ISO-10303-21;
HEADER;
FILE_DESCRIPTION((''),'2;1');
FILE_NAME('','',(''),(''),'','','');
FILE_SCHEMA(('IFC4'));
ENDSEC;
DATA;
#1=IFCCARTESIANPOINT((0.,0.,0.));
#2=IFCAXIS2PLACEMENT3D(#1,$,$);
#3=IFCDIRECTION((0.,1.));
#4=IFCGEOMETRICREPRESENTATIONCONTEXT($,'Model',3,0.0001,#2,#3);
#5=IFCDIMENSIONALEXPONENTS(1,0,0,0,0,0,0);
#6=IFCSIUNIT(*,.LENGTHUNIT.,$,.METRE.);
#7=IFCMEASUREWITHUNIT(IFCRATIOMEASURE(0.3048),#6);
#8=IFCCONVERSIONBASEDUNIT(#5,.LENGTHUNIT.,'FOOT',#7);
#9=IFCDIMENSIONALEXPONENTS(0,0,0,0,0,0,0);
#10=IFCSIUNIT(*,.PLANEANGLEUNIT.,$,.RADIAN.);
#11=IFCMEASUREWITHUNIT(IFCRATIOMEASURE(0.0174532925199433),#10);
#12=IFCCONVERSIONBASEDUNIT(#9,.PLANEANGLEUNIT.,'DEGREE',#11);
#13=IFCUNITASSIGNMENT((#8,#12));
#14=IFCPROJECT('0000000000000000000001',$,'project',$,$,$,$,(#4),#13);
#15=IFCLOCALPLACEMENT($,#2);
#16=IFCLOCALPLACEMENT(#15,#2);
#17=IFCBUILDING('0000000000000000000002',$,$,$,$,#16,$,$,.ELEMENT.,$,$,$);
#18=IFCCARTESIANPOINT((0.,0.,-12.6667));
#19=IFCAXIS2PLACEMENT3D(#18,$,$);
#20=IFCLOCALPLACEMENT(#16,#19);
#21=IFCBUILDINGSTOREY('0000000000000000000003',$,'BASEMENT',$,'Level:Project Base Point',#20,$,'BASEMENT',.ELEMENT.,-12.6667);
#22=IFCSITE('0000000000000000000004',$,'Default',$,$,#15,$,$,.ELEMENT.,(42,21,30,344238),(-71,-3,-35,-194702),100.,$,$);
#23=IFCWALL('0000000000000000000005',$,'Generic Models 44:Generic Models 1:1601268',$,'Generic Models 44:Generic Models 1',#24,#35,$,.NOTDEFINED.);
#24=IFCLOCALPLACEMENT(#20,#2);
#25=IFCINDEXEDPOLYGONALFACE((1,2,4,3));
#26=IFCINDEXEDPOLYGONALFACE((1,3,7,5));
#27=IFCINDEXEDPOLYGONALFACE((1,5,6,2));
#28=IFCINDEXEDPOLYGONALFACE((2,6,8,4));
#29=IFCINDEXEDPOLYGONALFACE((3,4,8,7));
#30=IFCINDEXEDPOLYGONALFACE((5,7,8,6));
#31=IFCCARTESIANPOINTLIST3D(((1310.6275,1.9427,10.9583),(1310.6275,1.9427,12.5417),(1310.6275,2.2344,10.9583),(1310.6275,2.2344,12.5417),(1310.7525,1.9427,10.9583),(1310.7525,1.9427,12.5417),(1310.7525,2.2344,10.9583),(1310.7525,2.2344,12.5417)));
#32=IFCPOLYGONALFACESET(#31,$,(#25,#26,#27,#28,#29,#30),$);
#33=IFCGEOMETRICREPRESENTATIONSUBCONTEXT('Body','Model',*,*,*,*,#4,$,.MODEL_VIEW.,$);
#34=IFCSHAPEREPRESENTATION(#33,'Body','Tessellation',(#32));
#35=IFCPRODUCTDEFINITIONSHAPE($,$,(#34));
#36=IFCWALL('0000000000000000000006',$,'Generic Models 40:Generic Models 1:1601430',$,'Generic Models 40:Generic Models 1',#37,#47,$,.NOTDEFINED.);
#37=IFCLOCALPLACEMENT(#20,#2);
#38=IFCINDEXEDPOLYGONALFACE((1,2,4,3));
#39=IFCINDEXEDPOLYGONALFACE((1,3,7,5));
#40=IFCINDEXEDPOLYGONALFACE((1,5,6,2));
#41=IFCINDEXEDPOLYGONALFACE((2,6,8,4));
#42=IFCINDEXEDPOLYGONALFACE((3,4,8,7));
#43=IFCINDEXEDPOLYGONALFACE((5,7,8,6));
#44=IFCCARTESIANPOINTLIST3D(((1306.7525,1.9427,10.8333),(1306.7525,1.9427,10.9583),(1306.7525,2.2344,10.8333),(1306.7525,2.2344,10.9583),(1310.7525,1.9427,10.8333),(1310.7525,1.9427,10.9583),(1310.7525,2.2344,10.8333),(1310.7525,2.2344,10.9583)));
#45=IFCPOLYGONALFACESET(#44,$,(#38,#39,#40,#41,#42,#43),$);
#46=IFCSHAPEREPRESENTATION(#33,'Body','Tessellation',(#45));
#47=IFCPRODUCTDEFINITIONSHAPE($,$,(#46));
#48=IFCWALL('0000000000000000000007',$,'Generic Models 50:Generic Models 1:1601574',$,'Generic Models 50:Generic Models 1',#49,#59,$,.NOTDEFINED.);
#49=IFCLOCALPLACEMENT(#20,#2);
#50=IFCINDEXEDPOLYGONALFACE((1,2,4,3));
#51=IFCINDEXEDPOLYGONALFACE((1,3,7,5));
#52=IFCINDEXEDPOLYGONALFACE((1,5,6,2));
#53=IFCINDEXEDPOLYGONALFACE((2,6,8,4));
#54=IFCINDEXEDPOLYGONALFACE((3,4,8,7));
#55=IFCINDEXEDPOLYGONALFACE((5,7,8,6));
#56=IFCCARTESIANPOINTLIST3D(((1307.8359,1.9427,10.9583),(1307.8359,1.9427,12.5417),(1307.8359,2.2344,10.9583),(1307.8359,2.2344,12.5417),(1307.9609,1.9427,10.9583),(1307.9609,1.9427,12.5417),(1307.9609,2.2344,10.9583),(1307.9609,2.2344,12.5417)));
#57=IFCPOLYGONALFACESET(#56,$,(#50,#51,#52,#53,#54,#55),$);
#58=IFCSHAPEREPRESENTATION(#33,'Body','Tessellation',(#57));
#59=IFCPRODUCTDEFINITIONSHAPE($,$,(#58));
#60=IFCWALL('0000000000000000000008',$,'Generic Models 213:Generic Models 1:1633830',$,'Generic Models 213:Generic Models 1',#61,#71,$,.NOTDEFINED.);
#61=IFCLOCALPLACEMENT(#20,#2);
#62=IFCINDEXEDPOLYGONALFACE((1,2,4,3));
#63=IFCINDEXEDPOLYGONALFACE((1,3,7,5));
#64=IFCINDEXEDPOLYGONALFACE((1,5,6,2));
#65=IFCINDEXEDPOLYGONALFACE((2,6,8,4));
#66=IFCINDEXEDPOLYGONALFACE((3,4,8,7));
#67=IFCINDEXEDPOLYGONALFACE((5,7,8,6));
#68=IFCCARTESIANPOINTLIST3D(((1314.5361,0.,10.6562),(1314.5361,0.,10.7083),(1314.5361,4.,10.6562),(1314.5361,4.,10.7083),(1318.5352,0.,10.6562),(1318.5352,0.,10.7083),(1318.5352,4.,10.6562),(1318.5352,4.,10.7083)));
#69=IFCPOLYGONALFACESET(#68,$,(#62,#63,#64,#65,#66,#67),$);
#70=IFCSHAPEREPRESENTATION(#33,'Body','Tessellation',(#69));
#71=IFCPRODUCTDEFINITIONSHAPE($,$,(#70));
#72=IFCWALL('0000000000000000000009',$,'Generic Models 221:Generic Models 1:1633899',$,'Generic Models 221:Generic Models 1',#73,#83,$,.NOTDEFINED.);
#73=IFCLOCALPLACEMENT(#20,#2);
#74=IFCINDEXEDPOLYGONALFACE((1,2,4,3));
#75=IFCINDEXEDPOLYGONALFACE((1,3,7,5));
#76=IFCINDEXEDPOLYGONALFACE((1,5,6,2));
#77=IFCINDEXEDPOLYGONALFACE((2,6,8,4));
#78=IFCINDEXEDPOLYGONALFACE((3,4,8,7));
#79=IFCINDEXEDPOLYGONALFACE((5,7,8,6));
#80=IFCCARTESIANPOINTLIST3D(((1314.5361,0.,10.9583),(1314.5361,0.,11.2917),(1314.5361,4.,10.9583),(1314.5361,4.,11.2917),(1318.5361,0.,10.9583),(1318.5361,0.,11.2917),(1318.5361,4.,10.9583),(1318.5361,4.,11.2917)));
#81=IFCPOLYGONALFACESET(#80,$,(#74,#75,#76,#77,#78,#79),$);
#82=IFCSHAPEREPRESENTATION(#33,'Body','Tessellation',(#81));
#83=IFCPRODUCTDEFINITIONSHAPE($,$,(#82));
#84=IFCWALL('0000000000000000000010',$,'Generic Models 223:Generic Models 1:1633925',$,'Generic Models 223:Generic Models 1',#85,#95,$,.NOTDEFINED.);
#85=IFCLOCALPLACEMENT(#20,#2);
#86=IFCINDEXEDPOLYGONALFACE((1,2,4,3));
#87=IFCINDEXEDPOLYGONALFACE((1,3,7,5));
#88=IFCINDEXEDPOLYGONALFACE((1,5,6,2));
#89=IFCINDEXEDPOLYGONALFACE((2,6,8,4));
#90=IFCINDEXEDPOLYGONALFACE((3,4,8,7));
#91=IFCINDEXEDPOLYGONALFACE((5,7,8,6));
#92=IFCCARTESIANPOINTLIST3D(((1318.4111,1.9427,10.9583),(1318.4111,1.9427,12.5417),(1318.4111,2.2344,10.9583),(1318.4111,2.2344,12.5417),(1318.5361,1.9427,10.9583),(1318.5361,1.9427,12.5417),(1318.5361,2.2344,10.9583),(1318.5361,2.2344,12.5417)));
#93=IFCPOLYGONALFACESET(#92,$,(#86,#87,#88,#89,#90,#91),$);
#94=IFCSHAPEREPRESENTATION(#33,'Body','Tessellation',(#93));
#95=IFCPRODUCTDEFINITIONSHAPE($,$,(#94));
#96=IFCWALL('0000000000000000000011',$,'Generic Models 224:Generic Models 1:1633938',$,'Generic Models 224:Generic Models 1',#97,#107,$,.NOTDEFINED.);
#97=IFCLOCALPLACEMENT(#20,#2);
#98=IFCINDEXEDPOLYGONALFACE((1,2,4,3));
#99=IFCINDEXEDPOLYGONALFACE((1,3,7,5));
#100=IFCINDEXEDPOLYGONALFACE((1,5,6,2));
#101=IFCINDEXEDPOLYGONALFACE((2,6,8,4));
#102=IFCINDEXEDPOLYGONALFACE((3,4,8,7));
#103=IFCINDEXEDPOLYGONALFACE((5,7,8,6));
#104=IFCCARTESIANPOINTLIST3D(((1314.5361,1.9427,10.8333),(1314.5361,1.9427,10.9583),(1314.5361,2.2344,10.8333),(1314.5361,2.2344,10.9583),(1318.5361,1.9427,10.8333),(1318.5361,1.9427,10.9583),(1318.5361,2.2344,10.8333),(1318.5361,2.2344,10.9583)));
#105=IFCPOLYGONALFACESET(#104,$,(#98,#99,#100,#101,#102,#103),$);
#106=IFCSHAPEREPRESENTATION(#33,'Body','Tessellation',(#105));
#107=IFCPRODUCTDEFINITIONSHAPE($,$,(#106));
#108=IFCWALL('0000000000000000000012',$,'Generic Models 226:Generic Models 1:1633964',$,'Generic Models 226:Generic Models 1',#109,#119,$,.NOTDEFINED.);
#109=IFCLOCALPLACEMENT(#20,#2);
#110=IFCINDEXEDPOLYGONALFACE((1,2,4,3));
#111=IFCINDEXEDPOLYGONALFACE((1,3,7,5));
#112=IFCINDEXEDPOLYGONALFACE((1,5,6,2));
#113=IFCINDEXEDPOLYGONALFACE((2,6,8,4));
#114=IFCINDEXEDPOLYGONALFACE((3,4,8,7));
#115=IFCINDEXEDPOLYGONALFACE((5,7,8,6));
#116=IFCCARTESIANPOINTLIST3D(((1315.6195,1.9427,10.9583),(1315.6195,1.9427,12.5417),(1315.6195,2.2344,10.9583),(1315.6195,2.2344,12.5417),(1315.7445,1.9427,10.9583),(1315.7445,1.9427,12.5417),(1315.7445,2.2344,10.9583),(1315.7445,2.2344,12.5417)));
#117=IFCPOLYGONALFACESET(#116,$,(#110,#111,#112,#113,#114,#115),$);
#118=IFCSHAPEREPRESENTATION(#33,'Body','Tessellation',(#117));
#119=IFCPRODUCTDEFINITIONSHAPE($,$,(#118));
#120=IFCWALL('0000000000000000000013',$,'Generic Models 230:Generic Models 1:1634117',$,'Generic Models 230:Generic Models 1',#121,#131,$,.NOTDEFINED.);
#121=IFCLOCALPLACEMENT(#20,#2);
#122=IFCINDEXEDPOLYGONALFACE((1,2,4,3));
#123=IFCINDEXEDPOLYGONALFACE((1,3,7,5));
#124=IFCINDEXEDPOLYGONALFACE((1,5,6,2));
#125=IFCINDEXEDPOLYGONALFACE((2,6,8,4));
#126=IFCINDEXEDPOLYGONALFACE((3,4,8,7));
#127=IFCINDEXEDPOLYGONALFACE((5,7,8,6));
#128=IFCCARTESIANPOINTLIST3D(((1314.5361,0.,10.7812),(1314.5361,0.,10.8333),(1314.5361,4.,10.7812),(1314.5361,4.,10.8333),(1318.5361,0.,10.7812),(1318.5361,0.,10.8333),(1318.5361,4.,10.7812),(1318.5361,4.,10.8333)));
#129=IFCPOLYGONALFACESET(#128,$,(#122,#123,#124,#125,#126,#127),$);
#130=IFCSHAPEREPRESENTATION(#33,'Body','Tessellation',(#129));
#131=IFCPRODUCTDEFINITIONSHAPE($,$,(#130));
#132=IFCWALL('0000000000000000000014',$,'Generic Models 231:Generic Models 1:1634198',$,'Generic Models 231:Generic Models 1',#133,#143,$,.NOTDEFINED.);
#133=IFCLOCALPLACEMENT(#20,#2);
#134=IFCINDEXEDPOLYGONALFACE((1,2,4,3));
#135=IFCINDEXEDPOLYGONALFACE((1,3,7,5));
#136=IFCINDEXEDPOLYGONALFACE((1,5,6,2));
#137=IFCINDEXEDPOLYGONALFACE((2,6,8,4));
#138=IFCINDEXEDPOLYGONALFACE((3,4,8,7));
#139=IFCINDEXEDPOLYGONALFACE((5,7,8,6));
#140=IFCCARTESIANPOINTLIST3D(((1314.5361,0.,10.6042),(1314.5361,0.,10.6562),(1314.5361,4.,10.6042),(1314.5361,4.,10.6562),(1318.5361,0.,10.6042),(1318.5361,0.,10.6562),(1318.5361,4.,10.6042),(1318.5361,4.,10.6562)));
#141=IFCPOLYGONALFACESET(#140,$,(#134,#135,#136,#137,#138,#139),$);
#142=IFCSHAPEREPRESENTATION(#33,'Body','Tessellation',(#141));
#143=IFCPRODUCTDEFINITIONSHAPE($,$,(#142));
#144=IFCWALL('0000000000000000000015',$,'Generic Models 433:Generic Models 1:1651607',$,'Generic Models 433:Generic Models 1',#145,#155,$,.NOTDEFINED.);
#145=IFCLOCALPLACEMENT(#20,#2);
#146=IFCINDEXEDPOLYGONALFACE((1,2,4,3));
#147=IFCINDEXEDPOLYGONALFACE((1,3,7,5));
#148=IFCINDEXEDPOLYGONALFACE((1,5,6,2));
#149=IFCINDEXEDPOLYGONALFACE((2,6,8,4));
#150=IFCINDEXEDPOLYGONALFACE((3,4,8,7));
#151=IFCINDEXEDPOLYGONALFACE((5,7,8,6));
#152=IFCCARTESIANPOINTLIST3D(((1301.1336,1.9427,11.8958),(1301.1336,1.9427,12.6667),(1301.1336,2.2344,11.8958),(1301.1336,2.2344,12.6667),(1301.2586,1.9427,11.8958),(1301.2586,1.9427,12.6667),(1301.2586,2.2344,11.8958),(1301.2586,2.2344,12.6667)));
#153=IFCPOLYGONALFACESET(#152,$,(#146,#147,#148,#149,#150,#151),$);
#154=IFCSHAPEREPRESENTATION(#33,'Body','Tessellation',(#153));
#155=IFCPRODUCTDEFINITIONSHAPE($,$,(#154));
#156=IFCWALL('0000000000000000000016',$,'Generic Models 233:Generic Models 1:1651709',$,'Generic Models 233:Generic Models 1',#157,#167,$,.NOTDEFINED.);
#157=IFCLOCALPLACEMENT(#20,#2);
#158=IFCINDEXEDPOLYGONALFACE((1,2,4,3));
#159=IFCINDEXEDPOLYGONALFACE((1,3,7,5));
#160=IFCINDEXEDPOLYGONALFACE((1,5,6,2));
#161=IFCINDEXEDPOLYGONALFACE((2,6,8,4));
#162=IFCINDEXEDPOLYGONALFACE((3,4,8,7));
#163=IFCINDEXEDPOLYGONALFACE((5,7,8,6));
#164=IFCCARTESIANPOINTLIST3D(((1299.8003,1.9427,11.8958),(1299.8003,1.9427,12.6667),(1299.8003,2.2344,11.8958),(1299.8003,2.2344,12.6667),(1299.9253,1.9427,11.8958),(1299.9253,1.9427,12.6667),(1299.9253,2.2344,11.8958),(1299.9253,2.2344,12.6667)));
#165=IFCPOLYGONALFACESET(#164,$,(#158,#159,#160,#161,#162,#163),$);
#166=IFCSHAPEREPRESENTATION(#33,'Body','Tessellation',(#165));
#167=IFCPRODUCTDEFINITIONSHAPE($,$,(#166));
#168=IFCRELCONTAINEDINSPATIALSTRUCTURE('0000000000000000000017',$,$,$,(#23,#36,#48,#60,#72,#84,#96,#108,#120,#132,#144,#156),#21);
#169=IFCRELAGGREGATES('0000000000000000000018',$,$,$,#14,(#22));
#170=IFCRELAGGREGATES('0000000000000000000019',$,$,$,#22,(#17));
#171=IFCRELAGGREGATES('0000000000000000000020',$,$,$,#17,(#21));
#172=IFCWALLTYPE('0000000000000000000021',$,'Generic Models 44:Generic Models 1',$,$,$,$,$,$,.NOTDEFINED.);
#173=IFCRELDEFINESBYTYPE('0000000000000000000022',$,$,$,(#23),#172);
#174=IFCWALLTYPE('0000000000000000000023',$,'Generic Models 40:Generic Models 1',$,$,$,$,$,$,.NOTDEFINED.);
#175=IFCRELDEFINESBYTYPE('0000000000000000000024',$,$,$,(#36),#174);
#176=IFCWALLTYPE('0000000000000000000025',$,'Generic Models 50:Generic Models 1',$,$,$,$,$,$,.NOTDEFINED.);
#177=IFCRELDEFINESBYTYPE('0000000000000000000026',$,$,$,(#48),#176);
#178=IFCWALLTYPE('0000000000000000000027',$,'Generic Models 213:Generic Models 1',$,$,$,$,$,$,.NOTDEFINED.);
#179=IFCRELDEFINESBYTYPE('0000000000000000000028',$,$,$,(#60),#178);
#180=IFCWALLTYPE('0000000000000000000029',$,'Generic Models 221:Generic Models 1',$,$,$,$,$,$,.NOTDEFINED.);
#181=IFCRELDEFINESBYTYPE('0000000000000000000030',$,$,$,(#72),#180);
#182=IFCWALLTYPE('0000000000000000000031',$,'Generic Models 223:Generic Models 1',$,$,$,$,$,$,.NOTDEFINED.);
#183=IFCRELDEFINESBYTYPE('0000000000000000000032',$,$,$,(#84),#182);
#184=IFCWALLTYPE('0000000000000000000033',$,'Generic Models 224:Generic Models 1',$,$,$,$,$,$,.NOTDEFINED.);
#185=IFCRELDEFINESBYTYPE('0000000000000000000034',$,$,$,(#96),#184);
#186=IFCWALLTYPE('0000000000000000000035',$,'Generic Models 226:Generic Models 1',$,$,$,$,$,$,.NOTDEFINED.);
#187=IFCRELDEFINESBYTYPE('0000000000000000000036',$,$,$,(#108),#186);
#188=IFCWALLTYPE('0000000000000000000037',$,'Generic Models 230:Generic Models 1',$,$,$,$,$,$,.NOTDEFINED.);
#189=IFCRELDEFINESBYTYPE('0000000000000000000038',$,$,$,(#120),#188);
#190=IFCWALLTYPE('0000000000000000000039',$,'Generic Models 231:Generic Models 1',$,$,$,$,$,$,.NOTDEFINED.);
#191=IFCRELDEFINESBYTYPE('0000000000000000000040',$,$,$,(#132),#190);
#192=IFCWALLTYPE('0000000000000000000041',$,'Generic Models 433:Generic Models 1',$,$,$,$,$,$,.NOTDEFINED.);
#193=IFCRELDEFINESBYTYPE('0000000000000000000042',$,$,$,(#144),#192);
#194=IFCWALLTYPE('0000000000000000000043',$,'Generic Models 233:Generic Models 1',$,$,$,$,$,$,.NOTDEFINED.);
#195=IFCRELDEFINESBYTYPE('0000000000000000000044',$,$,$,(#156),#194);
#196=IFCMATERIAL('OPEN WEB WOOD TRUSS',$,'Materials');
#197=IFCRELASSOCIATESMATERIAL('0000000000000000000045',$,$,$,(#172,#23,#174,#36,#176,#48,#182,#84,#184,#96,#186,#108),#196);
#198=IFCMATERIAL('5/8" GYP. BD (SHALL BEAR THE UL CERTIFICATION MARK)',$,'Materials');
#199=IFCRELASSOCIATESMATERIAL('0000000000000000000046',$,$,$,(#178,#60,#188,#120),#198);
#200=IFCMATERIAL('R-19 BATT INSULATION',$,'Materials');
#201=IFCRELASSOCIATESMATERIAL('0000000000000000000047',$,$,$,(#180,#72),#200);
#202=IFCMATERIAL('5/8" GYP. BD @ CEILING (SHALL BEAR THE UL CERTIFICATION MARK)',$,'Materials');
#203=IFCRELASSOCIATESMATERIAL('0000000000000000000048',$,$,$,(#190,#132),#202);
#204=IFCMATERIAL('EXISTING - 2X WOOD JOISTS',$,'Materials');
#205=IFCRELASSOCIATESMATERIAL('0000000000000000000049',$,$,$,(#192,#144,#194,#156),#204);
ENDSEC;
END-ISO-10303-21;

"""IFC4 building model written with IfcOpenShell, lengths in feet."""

from ifc_helpers import new_model, entity, si_unit, converted_unit, direction, frame, frame_2d, origin, origin_2d_with_axis, place, context, subcontext, project, spatial, rectangle, extrude, material, type_object, element, save


model = new_model("IFC4")

# Units and contexts
model_context = context("Model", 3, precision=0.0001, world=origin(), true_north=direction((0.0, 1.0)))
body_context = subcontext(model_context, "Body", "Model", "MODEL_VIEW")
ifc_project = project(units=[converted_unit("LENGTHUNIT", "FOOT", entity("IfcRatioMeasure", 0.3048), si_unit("LENGTHUNIT", "METRE"), dimensions=[1, 0, 0, 0, 0, 0, 0]), converted_unit("PLANEANGLEUNIT", "DEGREE", entity("IfcRatioMeasure", 0.0174532925199433), si_unit("PLANEANGLEUNIT", "RADIAN"), dimensions=[0, 0, 0, 0, 0, 0, 0])], contexts=[model_context])

# Site, building, storey
site_placement = place(None, origin())
site = spatial("IfcSite", under=ifc_project, at=site_placement, Name="Default", CompositionType="ELEMENT", RefLatitude=(42, 21, 30, 344238), RefLongitude=(-71, -3, -35, -194702), RefElevation=100.0)
building_placement = place(site_placement, origin())
building = spatial("IfcBuilding", under=site, at=building_placement, CompositionType="ELEMENT")
storey_placement = place(building_placement, frame((0.0, 0.0, -12.6667)))
storey = spatial("IfcBuildingStorey", under=building, at=storey_placement, Name="BASEMENT", ObjectType="Level:Project Base Point", LongName="BASEMENT", CompositionType="ELEMENT", Elevation=-12.6667)

# Walls
ifc_material_1 = material(Name="R-19 BATT INSULATION", Category="Materials")
ifc_material_2 = material(Name="OPEN WEB WOOD TRUSS", Category="Materials")
wall_type_1 = type_object("IfcWallType", Name="Generic Models 44:Generic Models 1", PredefinedType="NOTDEFINED", material=ifc_material_2)
wall_1_placement = place(storey_placement, frame((1310.6275, 1.9427, 10.9583), z_axis=(0.0, 0.0, 1.0), x_axis=(0.0, 1.0, 0.0)))
element("IfcWall", 1, at=wall_1_placement, inside=storey, type_object=wall_type_1, material=ifc_material_2, Name="Generic Models 44:Generic Models 1:1601268", ObjectType="Generic Models 44:Generic Models 1", PredefinedType="NOTDEFINED", context=body_context, shape_type="SweptSolid", body=[
    extrude(rectangle(XDim=0.2917, YDim=0.125, at=frame_2d((0.0, 0.0), x_axis=(1.0, 0.0))), frame((0.1458, -0.0625, 0.0)), (0.0, 0.0, 1.0), 1.5833),
])
wall_type_2 = type_object("IfcWallType", Name="Generic Models 40:Generic Models 1", PredefinedType="NOTDEFINED", material=ifc_material_2)
wall_2_placement = place(storey_placement, frame((1306.7525, 1.9427, 10.8333)))
element("IfcWall", 2, at=wall_2_placement, inside=storey, type_object=wall_type_2, material=ifc_material_2, Name="Generic Models 40:Generic Models 1:1601430", ObjectType="Generic Models 40:Generic Models 1", PredefinedType="NOTDEFINED", context=body_context, shape_type="SweptSolid", body=[
    extrude(rectangle(XDim=0.2917, YDim=4.0, at=frame_2d((0.0, 0.0), x_axis=(1.0, 0.0))), frame((2.0, 0.1458, 0.0), z_axis=(0.0, 0.0, 1.0), x_axis=(0.0, 1.0, 0.0)), (0.0, 0.0, 1.0), 0.125),
])
wall_type_3 = type_object("IfcWallType", Name="Generic Models 50:Generic Models 1", PredefinedType="NOTDEFINED", material=ifc_material_2)
wall_3_placement = place(storey_placement, frame((1307.8359, 1.9427, 10.9583), z_axis=(0.0, 0.0, 1.0), x_axis=(0.0, 1.0, 0.0)))
element("IfcWall", 3, at=wall_3_placement, inside=storey, type_object=wall_type_3, material=ifc_material_2, Name="Generic Models 50:Generic Models 1:1601574", ObjectType="Generic Models 50:Generic Models 1", PredefinedType="NOTDEFINED", context=body_context, shape_type="SweptSolid", body=[
    extrude(rectangle(XDim=0.2917, YDim=0.125, at=frame_2d((0.0, 0.0), x_axis=(1.0, 0.0))), frame((0.1458, -0.0625, 0.0)), (0.0, 0.0, 1.0), 1.5833),
])
ifc_material_3 = material(Name="5/8\" GYP. BD (SHALL BEAR THE UL CERTIFICATION MARK)", Category="Materials")
wall_type_4 = type_object("IfcWallType", Name="Generic Models 213:Generic Models 1", PredefinedType="NOTDEFINED", material=ifc_material_3)
wall_4_placement = place(storey_placement, frame((1314.5361, 0.0, 10.6562), z_axis=(0.0, 0.0, 1.0), x_axis=(0.0, 1.0, 0.0)))
element("IfcWall", 4, at=wall_4_placement, inside=storey, type_object=wall_type_4, material=ifc_material_3, Name="Generic Models 213:Generic Models 1:1633830", ObjectType="Generic Models 213:Generic Models 1", PredefinedType="NOTDEFINED", context=body_context, shape_type="SweptSolid", body=[
    extrude(rectangle(XDim=4.0, YDim=3.999, at=origin_2d_with_axis()), frame((2.0, -1.9995, 0.0)), (0.0, 0.0, 1.0), 0.0521),
])
wall_type_5 = type_object("IfcWallType", Name="Generic Models 221:Generic Models 1", PredefinedType="NOTDEFINED", material=ifc_material_1)
wall_5_placement = place(storey_placement, frame((1314.5361, 0.0, 10.9583), z_axis=(0.0, 0.0, 1.0), x_axis=(0.0, 1.0, 0.0)))
element("IfcWall", 5, at=wall_5_placement, inside=storey, type_object=wall_type_5, material=ifc_material_1, Name="Generic Models 221:Generic Models 1:1633899", ObjectType="Generic Models 221:Generic Models 1", PredefinedType="NOTDEFINED", context=body_context, shape_type="SweptSolid", body=[
    extrude(rectangle(XDim=4.0, YDim=4.0, at=frame_2d((0.0, 0.0), x_axis=(1.0, 0.0))), frame((2.0, -2.0, 0.0)), (0.0, 0.0, 1.0), 0.3333),
])
wall_type_6 = type_object("IfcWallType", Name="Generic Models 223:Generic Models 1", PredefinedType="NOTDEFINED", material=ifc_material_2)
wall_6_placement = place(storey_placement, frame((1318.4111, 1.9427, 10.9583), z_axis=(0.0, 0.0, 1.0), x_axis=(0.0, 1.0, 0.0)))
element("IfcWall", 6, at=wall_6_placement, inside=storey, type_object=wall_type_6, material=ifc_material_2, Name="Generic Models 223:Generic Models 1:1633925", ObjectType="Generic Models 223:Generic Models 1", PredefinedType="NOTDEFINED", context=body_context, shape_type="SweptSolid", body=[
    extrude(rectangle(XDim=0.2917, YDim=0.125, at=frame_2d((0.0, 0.0), x_axis=(1.0, 0.0))), frame((0.1458, -0.0625, 0.0)), (0.0, 0.0, 1.0), 1.5833),
])
wall_type_7 = type_object("IfcWallType", Name="Generic Models 224:Generic Models 1", PredefinedType="NOTDEFINED", material=ifc_material_2)
wall_7_placement = place(storey_placement, frame((1314.5361, 1.9427, 10.8333)))
element("IfcWall", 7, at=wall_7_placement, inside=storey, type_object=wall_type_7, material=ifc_material_2, Name="Generic Models 224:Generic Models 1:1633938", ObjectType="Generic Models 224:Generic Models 1", PredefinedType="NOTDEFINED", context=body_context, shape_type="SweptSolid", body=[
    extrude(rectangle(XDim=0.2917, YDim=4.0, at=frame_2d((0.0, 0.0), x_axis=(1.0, 0.0))), frame((2.0, 0.1458, 0.0), z_axis=(0.0, 0.0, 1.0), x_axis=(0.0, 1.0, 0.0)), (0.0, 0.0, 1.0), 0.125),
])
wall_type_8 = type_object("IfcWallType", Name="Generic Models 226:Generic Models 1", PredefinedType="NOTDEFINED", material=ifc_material_2)
wall_8_placement = place(storey_placement, frame((1315.6195, 1.9427, 10.9583), z_axis=(0.0, 0.0, 1.0), x_axis=(0.0, 1.0, 0.0)))
element("IfcWall", 8, at=wall_8_placement, inside=storey, type_object=wall_type_8, material=ifc_material_2, Name="Generic Models 226:Generic Models 1:1633964", ObjectType="Generic Models 226:Generic Models 1", PredefinedType="NOTDEFINED", context=body_context, shape_type="SweptSolid", body=[
    extrude(rectangle(XDim=0.2917, YDim=0.125, at=frame_2d((0.0, 0.0), x_axis=(1.0, 0.0))), frame((0.1458, -0.0625, 0.0)), (0.0, 0.0, 1.0), 1.5833),
])
wall_type_9 = type_object("IfcWallType", Name="Generic Models 230:Generic Models 1", PredefinedType="NOTDEFINED", material=ifc_material_3)
wall_9_placement = place(storey_placement, frame((1314.5361, 0.0, 10.7812), z_axis=(0.0, 0.0, 1.0), x_axis=(0.0, 1.0, 0.0)))
element("IfcWall", 9, at=wall_9_placement, inside=storey, type_object=wall_type_9, material=ifc_material_3, Name="Generic Models 230:Generic Models 1:1634117", ObjectType="Generic Models 230:Generic Models 1", PredefinedType="NOTDEFINED", context=body_context, shape_type="SweptSolid", body=[
    extrude(rectangle(XDim=4.0, YDim=4.0, at=origin_2d_with_axis()), frame((2.0, -2.0, 0.0)), (0.0, 0.0, 1.0), 0.0521),
])
ifc_material_4 = material(Name="5/8\" GYP. BD @ CEILING (SHALL BEAR THE UL CERTIFICATION MARK)", Category="Materials")
wall_type_10 = type_object("IfcWallType", Name="Generic Models 231:Generic Models 1", PredefinedType="NOTDEFINED", material=ifc_material_4)
wall_10_placement = place(storey_placement, frame((1314.5361, 0.0, 10.6042), z_axis=(0.0, 0.0, 1.0), x_axis=(0.0, 1.0, 0.0)))
element("IfcWall", 10, at=wall_10_placement, inside=storey, type_object=wall_type_10, material=ifc_material_4, Name="Generic Models 231:Generic Models 1:1634198", ObjectType="Generic Models 231:Generic Models 1", PredefinedType="NOTDEFINED", context=body_context, shape_type="SweptSolid", body=[
    extrude(rectangle(XDim=4.0, YDim=4.0, at=origin_2d_with_axis()), frame((2.0, -2.0, 0.0)), (0.0, 0.0, 1.0), 0.0521),
])
ifc_material_5 = material(Name="EXISTING - 2X WOOD JOISTS", Category="Materials")
wall_type_11 = type_object("IfcWallType", Name="Generic Models 433:Generic Models 1", PredefinedType="NOTDEFINED", material=ifc_material_5)
wall_11_placement = place(storey_placement, frame((1301.1336, 1.9427, 11.8958), z_axis=(0.0, 0.0, 1.0), x_axis=(0.0, 1.0, 0.0)))
element("IfcWall", 11, at=wall_11_placement, inside=storey, type_object=wall_type_11, material=ifc_material_5, Name="Generic Models 433:Generic Models 1:1651607", ObjectType="Generic Models 433:Generic Models 1", PredefinedType="NOTDEFINED", context=body_context, shape_type="SweptSolid", body=[
    extrude(rectangle(XDim=0.2917, YDim=0.125, at=frame_2d((0.0, 0.0), x_axis=(1.0, 0.0))), frame((0.1458, -0.0625, 0.0)), (0.0, 0.0, 1.0), 0.7708),
])
wall_type_12 = type_object("IfcWallType", Name="Generic Models 233:Generic Models 1", PredefinedType="NOTDEFINED", material=ifc_material_5)
wall_12_placement = place(storey_placement, frame((1299.8003, 1.9427, 11.8958), z_axis=(0.0, 0.0, 1.0), x_axis=(0.0, 1.0, 0.0)))
element("IfcWall", 12, at=wall_12_placement, inside=storey, type_object=wall_type_12, material=ifc_material_5, Name="Generic Models 233:Generic Models 1:1651709", ObjectType="Generic Models 233:Generic Models 1", PredefinedType="NOTDEFINED", context=body_context, shape_type="SweptSolid", body=[
    extrude(rectangle(XDim=0.2917, YDim=0.125, at=frame_2d((0.0, 0.0), x_axis=(1.0, 0.0))), frame((0.1458, -0.0625, 0.0)), (0.0, 0.0, 1.0), 0.7708),
])

save(model, "model.ifc")
